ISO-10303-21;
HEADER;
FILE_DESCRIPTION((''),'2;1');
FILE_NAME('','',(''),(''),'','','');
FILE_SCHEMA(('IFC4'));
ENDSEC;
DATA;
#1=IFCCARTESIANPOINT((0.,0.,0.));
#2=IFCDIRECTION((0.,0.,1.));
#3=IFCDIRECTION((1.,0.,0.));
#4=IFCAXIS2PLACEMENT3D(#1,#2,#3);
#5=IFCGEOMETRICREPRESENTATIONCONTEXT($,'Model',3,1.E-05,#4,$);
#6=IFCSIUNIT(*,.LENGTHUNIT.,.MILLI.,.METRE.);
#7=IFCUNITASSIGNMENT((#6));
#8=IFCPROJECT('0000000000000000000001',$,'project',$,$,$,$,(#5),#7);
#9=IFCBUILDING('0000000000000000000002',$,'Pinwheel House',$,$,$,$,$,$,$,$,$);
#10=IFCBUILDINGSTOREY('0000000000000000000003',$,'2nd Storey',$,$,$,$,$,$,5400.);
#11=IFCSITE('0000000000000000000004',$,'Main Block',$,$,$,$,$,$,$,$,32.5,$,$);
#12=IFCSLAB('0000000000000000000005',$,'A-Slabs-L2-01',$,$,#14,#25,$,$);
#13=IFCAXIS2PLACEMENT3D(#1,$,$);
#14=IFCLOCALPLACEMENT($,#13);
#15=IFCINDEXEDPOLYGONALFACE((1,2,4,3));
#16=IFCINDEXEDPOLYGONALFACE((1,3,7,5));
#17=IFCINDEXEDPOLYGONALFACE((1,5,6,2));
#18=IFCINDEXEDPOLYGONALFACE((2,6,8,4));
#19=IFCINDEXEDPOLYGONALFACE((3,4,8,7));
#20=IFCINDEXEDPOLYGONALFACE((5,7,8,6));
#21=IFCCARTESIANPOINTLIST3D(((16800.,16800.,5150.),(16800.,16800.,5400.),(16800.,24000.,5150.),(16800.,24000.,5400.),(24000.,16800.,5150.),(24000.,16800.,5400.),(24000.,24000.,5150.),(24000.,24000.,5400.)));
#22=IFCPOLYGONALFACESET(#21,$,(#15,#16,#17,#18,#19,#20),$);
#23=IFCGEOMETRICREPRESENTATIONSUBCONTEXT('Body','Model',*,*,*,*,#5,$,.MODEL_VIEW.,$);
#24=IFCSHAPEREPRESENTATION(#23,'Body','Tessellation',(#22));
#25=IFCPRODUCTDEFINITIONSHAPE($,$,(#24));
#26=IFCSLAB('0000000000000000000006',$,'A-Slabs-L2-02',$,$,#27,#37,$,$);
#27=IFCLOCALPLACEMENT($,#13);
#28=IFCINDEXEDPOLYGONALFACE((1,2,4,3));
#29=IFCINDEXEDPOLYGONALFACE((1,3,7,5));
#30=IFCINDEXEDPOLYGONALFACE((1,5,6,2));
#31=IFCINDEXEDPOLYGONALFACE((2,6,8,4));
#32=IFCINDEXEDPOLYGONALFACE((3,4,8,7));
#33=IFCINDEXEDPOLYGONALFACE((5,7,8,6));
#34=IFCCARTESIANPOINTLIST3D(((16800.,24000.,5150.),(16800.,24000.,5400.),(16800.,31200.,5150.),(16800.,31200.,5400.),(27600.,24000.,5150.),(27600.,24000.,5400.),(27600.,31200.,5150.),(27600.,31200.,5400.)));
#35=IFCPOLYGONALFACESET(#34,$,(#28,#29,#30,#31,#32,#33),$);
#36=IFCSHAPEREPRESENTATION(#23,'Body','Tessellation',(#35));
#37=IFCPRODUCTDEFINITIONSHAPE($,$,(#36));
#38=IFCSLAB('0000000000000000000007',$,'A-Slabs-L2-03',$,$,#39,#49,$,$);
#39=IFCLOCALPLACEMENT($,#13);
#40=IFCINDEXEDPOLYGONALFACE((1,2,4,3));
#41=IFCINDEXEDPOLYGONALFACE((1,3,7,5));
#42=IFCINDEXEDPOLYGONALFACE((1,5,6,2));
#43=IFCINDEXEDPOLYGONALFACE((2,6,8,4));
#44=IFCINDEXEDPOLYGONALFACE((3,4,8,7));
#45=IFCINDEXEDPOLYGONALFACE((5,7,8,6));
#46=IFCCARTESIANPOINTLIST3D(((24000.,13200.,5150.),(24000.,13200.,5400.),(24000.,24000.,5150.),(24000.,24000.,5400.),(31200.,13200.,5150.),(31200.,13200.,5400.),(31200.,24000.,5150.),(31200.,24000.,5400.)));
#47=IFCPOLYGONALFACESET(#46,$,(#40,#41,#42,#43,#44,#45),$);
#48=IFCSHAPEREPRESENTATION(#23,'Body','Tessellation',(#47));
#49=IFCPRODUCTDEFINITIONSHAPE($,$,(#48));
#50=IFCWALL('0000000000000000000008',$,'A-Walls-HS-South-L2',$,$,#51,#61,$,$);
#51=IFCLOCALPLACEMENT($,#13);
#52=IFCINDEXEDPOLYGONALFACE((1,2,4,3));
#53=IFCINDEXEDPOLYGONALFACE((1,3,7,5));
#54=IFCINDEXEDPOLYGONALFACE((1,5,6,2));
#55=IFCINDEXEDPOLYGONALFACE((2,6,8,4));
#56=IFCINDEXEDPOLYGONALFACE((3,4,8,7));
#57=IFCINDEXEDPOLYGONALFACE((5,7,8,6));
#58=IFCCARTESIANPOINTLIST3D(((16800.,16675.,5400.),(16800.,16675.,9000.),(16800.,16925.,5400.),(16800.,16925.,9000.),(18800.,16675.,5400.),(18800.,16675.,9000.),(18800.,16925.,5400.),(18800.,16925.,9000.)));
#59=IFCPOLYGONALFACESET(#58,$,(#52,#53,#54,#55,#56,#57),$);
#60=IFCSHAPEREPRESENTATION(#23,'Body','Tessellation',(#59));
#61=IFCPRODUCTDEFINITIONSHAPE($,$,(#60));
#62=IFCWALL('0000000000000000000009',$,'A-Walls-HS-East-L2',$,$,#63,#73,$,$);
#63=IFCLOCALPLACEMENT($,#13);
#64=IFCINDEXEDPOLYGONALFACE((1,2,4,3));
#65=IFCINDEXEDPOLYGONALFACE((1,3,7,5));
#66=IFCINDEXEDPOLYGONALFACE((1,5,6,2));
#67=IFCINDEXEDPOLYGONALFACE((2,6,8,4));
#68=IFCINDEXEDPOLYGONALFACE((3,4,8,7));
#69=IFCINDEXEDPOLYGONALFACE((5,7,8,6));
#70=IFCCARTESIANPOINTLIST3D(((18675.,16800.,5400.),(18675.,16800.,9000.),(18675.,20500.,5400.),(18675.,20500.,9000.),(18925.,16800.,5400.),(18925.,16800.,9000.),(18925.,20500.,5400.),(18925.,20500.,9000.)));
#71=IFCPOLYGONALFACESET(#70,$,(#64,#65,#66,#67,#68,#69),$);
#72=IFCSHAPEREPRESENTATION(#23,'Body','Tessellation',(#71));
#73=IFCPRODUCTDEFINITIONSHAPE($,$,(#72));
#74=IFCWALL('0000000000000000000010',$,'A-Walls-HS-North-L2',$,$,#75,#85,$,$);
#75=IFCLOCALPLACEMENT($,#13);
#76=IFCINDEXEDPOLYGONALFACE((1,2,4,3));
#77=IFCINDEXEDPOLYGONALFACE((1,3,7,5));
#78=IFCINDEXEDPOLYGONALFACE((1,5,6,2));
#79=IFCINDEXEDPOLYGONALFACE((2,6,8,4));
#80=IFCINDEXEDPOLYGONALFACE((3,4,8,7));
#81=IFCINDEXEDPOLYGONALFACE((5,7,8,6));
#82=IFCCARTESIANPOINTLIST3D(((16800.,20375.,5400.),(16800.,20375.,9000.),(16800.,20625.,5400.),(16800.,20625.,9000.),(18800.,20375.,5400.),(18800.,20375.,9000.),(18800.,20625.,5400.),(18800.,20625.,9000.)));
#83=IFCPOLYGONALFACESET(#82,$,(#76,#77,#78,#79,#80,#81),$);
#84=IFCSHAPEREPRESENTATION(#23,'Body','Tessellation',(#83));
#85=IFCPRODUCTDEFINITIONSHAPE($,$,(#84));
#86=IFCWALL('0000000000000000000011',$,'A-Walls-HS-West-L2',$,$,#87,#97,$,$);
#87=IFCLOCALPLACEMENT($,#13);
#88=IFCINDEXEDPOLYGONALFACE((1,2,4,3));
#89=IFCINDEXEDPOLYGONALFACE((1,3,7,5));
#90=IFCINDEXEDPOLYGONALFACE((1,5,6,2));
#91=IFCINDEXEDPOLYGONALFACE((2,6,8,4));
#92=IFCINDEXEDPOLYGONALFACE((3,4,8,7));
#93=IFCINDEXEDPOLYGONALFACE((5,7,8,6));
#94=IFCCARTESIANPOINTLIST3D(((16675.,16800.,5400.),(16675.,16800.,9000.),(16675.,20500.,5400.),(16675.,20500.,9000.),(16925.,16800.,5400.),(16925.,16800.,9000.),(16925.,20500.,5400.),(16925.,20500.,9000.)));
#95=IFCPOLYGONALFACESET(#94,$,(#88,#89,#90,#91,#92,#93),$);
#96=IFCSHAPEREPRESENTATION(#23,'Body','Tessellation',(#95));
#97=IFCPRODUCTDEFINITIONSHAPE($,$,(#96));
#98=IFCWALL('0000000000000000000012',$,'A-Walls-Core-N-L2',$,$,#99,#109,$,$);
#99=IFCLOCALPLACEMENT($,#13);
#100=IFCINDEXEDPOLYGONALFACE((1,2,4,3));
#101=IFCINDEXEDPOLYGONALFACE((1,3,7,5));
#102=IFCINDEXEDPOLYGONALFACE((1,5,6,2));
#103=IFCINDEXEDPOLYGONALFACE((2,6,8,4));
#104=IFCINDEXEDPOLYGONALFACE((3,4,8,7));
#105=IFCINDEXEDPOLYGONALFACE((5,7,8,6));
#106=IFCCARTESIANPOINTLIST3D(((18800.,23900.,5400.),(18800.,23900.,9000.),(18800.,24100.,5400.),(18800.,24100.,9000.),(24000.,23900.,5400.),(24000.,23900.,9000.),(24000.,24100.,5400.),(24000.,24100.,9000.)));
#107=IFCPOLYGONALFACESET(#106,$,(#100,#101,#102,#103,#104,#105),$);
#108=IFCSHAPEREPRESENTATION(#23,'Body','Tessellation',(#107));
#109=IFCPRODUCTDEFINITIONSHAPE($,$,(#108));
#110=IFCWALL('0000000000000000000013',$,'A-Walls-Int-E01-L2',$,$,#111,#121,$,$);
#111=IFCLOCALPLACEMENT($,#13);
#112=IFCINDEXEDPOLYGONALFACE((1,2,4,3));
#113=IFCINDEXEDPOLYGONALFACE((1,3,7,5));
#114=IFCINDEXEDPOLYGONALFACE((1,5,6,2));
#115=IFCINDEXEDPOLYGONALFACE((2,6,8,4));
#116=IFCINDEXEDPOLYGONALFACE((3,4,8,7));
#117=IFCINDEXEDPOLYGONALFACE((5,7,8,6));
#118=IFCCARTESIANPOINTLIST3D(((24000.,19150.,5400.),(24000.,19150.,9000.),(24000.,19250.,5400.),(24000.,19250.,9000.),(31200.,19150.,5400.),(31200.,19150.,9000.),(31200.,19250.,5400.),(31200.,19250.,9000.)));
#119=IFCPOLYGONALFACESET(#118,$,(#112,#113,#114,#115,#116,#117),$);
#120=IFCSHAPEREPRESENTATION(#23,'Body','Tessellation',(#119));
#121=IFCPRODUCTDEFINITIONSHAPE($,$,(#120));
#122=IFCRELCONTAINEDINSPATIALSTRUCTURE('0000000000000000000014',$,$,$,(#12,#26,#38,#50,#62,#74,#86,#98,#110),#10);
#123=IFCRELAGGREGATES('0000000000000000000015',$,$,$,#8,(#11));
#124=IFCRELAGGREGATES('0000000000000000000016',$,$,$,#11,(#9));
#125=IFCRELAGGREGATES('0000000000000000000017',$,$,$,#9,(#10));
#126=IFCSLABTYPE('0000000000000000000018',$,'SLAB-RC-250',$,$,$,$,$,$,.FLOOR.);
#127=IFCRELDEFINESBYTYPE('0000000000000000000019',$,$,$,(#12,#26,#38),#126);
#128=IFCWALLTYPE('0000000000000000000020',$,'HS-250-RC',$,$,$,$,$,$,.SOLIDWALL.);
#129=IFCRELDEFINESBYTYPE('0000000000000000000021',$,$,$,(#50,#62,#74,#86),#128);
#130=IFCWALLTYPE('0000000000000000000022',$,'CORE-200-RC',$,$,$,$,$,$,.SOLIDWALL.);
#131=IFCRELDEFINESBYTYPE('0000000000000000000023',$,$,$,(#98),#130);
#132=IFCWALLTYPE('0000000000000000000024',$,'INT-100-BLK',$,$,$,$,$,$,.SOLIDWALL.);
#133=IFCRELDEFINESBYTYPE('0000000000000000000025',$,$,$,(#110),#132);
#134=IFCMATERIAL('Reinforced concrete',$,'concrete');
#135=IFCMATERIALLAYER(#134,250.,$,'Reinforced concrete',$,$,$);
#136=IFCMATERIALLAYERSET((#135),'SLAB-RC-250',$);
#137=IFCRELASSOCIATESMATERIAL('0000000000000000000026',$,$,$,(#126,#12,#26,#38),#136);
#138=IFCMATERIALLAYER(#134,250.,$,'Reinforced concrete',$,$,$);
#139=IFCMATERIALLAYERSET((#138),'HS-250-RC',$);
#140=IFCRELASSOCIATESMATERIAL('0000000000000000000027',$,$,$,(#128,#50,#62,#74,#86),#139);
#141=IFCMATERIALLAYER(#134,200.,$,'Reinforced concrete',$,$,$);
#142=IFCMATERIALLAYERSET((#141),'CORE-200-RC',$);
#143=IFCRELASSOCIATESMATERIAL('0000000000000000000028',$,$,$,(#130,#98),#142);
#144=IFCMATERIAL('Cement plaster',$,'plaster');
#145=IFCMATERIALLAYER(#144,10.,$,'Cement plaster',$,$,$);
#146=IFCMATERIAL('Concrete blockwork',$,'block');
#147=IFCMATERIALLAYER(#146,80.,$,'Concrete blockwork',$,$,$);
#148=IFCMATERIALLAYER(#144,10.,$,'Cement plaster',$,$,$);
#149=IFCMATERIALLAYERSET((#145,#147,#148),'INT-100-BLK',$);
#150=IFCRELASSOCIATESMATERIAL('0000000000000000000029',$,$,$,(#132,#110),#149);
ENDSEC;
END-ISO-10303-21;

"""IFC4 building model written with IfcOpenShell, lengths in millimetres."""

from ifc_helpers import new_model, si_unit, frame, origin_with_axes, place, context, subcontext, project, spatial, indexed_curve, outline, extrude, material, layer, layer_set, layer_usage, type_object, element, save


model = new_model("IFC4")

# Units and contexts
model_context = context("Model", 3, precision=1e-05, world=origin_with_axes())
body_context = subcontext(model_context, "Body", "Model", "MODEL_VIEW")
ifc_project = project(units=[si_unit("LENGTHUNIT", "METRE", prefix="MILLI")], contexts=[model_context])

# Site, building, storey
site = spatial("IfcSite", under=ifc_project, Name="Main Block", RefElevation=32.5)
building = spatial("IfcBuilding", under=site, Name="Pinwheel House")
storey = spatial("IfcBuildingStorey", under=building, Name="2nd Storey", Elevation=5400.0)

# Slabs
ifc_material_1 = material(Name="Reinforced concrete", Category="concrete")
ifc_layer_1 = layer(ifc_material_1, 250.0, Name="Reinforced concrete")
ifc_layer_set_1 = layer_set([ifc_layer_1], Name="SLAB-RC-250")
ifc_layer_usage_1 = layer_usage(ifc_layer_set_1, "AXIS3", "POSITIVE", 0.0)
slab_type = type_object("IfcSlabType", Name="SLAB-RC-250", PredefinedType="FLOOR", material=ifc_layer_set_1)
slab_1_placement = place(None, frame((0.0, 0.0, 5150.0), z_axis=(0.0, 0.0, 1.0), x_axis=(1.0, 0.0, 0.0)))
element("IfcSlab", 1, at=slab_1_placement, inside=storey, type_object=slab_type, material=ifc_layer_usage_1, Name="A-Slabs-L2-01", context=body_context, shape_type="SweptSolid", body=[
    extrude(outline(indexed_curve([(16800.0, 16800.0), (24000.0, 16800.0), (24000.0, 24000.0), (16800.0, 24000.0)])), None, (0.0, 0.0, 1.0), 250.0),
])
ifc_layer_usage_2 = layer_usage(ifc_layer_set_1, "AXIS3", "POSITIVE", 0.0)
slab_2_placement = place(None, frame((0.0, 0.0, 5150.0), z_axis=(0.0, 0.0, 1.0), x_axis=(1.0, 0.0, 0.0)))
element("IfcSlab", 2, at=slab_2_placement, inside=storey, type_object=slab_type, material=ifc_layer_usage_2, Name="A-Slabs-L2-02", context=body_context, shape_type="SweptSolid", body=[
    extrude(outline(indexed_curve([(16800.0, 24000.0), (27600.0, 24000.0), (27600.0, 31200.0), (16800.0, 31200.0)])), None, (0.0, 0.0, 1.0), 250.0),
])
ifc_layer_usage_3 = layer_usage(ifc_layer_set_1, "AXIS3", "POSITIVE", 0.0)
slab_3_placement = place(None, frame((0.0, 0.0, 5150.0), z_axis=(0.0, 0.0, 1.0), x_axis=(1.0, 0.0, 0.0)))
element("IfcSlab", 3, at=slab_3_placement, inside=storey, type_object=slab_type, material=ifc_layer_usage_3, Name="A-Slabs-L2-03", context=body_context, shape_type="SweptSolid", body=[
    extrude(outline(indexed_curve([(24000.0, 13200.0), (31200.0, 13200.0), (31200.0, 24000.0), (24000.0, 24000.0)])), None, (0.0, 0.0, 1.0), 250.0),
])

# Walls
ifc_layer_2 = layer(ifc_material_1, 250.0, Name="Reinforced concrete")
ifc_layer_set_2 = layer_set([ifc_layer_2], Name="HS-250-RC")
ifc_layer_usage_4 = layer_usage(ifc_layer_set_2, "AXIS2", "POSITIVE", 0.0)
wall_type_1 = type_object("IfcWallType", Name="HS-250-RC", PredefinedType="SOLIDWALL", material=ifc_layer_set_2)
wall_1_placement = place(None, frame((16800.0, 16675.0, 5400.0), z_axis=(0.0, 0.0, 1.0), x_axis=(1.0, 0.0, 0.0)))
element("IfcWall", 4, at=wall_1_placement, inside=storey, type_object=wall_type_1, material=ifc_layer_usage_4, Name="A-Walls-HS-South-L2", context=body_context, shape_type="SweptSolid", body=[
    extrude(outline(indexed_curve([(0.0, 0.0), (0.0, 250.0), (2000.0, 250.0), (2000.0, 0.0), (0.0, 0.0)], self_intersect=False)), origin_with_axes(), (0.0, 0.0, 1.0), 3600.0),
])
ifc_layer_usage_5 = layer_usage(ifc_layer_set_2, "AXIS2", "POSITIVE", 0.0)
wall_2_placement = place(None, frame((18925.0, 16800.0, 5400.0), z_axis=(0.0, 0.0, 1.0), x_axis=(0.0, 1.0, 0.0)))
element("IfcWall", 5, at=wall_2_placement, inside=storey, type_object=wall_type_1, material=ifc_layer_usage_5, Name="A-Walls-HS-East-L2", context=body_context, shape_type="SweptSolid", body=[
    extrude(outline(indexed_curve([(0.0, 0.0), (0.0, 250.0), (3700.0, 250.0), (3700.0, 0.0), (0.0, 0.0)], self_intersect=False)), origin_with_axes(), (0.0, 0.0, 1.0), 3600.0),
])
ifc_layer_usage_6 = layer_usage(ifc_layer_set_2, "AXIS2", "POSITIVE", 0.0)
wall_3_placement = place(None, frame((18800.0, 20625.0, 5400.0), z_axis=(0.0, 0.0, 1.0), x_axis=(-1.0, 0.0, 0.0)))
element("IfcWall", 6, at=wall_3_placement, inside=storey, type_object=wall_type_1, material=ifc_layer_usage_6, Name="A-Walls-HS-North-L2", context=body_context, shape_type="SweptSolid", body=[
    extrude(outline(indexed_curve([(0.0, 0.0), (0.0, 250.0), (2000.0, 250.0), (2000.0, 0.0), (0.0, 0.0)], self_intersect=False)), origin_with_axes(), (0.0, 0.0, 1.0), 3600.0),
])
ifc_layer_usage_7 = layer_usage(ifc_layer_set_2, "AXIS2", "POSITIVE", 0.0)
wall_4_placement = place(None, frame((16675.0, 20500.0, 5400.0), z_axis=(0.0, 0.0, 1.0), x_axis=(0.0, -1.0, 0.0)))
element("IfcWall", 7, at=wall_4_placement, inside=storey, type_object=wall_type_1, material=ifc_layer_usage_7, Name="A-Walls-HS-West-L2", context=body_context, shape_type="SweptSolid", body=[
    extrude(outline(indexed_curve([(0.0, 0.0), (0.0, 250.0), (3700.0, 250.0), (3700.0, 0.0), (0.0, 0.0)], self_intersect=False)), origin_with_axes(), (0.0, 0.0, 1.0), 3600.0),
])
ifc_layer_3 = layer(ifc_material_1, 200.0, Name="Reinforced concrete")
ifc_layer_set_3 = layer_set([ifc_layer_3], Name="CORE-200-RC")
ifc_layer_usage_8 = layer_usage(ifc_layer_set_3, "AXIS2", "POSITIVE", 0.0)
wall_type_2 = type_object("IfcWallType", Name="CORE-200-RC", PredefinedType="SOLIDWALL", material=ifc_layer_set_3)
wall_5_placement = place(None, frame((18800.0, 23900.0, 5400.0), z_axis=(0.0, 0.0, 1.0), x_axis=(1.0, 0.0, 0.0)))
element("IfcWall", 8, at=wall_5_placement, inside=storey, type_object=wall_type_2, material=ifc_layer_usage_8, Name="A-Walls-Core-N-L2", context=body_context, shape_type="SweptSolid", body=[
    extrude(outline(indexed_curve([(0.0, 0.0), (0.0, 200.0), (5200.0, 200.0), (5200.0, 0.0), (0.0, 0.0)], self_intersect=False)), origin_with_axes(), (0.0, 0.0, 1.0), 3600.0),
])
ifc_material_2 = material(Name="Cement plaster", Category="plaster")
ifc_layer_4 = layer(ifc_material_2, 10.0, Name="Cement plaster")
ifc_material_3 = material(Name="Concrete blockwork", Category="block")
ifc_layer_5 = layer(ifc_material_3, 80.0, Name="Concrete blockwork")
ifc_layer_6 = layer(ifc_material_2, 10.0, Name="Cement plaster")
ifc_layer_set_4 = layer_set([ifc_layer_4, ifc_layer_5, ifc_layer_6], Name="INT-100-BLK")
ifc_layer_usage_9 = layer_usage(ifc_layer_set_4, "AXIS2", "POSITIVE", 0.0)
wall_type_3 = type_object("IfcWallType", Name="INT-100-BLK", PredefinedType="SOLIDWALL", material=ifc_layer_set_4)
wall_6_placement = place(None, frame((24000.0, 19150.0, 5400.0), z_axis=(0.0, 0.0, 1.0), x_axis=(1.0, 0.0, 0.0)))
element("IfcWall", 9, at=wall_6_placement, inside=storey, type_object=wall_type_3, material=ifc_layer_usage_9, Name="A-Walls-Int-E01-L2", context=body_context, shape_type="SweptSolid", body=[
    extrude(outline(indexed_curve([(0.0, 0.0), (0.0, 100.0), (7200.0, 100.0), (7200.0, 0.0), (0.0, 0.0)], self_intersect=False)), origin_with_axes(), (0.0, 0.0, 1.0), 3600.0),
])

save(model, "model.ifc")
